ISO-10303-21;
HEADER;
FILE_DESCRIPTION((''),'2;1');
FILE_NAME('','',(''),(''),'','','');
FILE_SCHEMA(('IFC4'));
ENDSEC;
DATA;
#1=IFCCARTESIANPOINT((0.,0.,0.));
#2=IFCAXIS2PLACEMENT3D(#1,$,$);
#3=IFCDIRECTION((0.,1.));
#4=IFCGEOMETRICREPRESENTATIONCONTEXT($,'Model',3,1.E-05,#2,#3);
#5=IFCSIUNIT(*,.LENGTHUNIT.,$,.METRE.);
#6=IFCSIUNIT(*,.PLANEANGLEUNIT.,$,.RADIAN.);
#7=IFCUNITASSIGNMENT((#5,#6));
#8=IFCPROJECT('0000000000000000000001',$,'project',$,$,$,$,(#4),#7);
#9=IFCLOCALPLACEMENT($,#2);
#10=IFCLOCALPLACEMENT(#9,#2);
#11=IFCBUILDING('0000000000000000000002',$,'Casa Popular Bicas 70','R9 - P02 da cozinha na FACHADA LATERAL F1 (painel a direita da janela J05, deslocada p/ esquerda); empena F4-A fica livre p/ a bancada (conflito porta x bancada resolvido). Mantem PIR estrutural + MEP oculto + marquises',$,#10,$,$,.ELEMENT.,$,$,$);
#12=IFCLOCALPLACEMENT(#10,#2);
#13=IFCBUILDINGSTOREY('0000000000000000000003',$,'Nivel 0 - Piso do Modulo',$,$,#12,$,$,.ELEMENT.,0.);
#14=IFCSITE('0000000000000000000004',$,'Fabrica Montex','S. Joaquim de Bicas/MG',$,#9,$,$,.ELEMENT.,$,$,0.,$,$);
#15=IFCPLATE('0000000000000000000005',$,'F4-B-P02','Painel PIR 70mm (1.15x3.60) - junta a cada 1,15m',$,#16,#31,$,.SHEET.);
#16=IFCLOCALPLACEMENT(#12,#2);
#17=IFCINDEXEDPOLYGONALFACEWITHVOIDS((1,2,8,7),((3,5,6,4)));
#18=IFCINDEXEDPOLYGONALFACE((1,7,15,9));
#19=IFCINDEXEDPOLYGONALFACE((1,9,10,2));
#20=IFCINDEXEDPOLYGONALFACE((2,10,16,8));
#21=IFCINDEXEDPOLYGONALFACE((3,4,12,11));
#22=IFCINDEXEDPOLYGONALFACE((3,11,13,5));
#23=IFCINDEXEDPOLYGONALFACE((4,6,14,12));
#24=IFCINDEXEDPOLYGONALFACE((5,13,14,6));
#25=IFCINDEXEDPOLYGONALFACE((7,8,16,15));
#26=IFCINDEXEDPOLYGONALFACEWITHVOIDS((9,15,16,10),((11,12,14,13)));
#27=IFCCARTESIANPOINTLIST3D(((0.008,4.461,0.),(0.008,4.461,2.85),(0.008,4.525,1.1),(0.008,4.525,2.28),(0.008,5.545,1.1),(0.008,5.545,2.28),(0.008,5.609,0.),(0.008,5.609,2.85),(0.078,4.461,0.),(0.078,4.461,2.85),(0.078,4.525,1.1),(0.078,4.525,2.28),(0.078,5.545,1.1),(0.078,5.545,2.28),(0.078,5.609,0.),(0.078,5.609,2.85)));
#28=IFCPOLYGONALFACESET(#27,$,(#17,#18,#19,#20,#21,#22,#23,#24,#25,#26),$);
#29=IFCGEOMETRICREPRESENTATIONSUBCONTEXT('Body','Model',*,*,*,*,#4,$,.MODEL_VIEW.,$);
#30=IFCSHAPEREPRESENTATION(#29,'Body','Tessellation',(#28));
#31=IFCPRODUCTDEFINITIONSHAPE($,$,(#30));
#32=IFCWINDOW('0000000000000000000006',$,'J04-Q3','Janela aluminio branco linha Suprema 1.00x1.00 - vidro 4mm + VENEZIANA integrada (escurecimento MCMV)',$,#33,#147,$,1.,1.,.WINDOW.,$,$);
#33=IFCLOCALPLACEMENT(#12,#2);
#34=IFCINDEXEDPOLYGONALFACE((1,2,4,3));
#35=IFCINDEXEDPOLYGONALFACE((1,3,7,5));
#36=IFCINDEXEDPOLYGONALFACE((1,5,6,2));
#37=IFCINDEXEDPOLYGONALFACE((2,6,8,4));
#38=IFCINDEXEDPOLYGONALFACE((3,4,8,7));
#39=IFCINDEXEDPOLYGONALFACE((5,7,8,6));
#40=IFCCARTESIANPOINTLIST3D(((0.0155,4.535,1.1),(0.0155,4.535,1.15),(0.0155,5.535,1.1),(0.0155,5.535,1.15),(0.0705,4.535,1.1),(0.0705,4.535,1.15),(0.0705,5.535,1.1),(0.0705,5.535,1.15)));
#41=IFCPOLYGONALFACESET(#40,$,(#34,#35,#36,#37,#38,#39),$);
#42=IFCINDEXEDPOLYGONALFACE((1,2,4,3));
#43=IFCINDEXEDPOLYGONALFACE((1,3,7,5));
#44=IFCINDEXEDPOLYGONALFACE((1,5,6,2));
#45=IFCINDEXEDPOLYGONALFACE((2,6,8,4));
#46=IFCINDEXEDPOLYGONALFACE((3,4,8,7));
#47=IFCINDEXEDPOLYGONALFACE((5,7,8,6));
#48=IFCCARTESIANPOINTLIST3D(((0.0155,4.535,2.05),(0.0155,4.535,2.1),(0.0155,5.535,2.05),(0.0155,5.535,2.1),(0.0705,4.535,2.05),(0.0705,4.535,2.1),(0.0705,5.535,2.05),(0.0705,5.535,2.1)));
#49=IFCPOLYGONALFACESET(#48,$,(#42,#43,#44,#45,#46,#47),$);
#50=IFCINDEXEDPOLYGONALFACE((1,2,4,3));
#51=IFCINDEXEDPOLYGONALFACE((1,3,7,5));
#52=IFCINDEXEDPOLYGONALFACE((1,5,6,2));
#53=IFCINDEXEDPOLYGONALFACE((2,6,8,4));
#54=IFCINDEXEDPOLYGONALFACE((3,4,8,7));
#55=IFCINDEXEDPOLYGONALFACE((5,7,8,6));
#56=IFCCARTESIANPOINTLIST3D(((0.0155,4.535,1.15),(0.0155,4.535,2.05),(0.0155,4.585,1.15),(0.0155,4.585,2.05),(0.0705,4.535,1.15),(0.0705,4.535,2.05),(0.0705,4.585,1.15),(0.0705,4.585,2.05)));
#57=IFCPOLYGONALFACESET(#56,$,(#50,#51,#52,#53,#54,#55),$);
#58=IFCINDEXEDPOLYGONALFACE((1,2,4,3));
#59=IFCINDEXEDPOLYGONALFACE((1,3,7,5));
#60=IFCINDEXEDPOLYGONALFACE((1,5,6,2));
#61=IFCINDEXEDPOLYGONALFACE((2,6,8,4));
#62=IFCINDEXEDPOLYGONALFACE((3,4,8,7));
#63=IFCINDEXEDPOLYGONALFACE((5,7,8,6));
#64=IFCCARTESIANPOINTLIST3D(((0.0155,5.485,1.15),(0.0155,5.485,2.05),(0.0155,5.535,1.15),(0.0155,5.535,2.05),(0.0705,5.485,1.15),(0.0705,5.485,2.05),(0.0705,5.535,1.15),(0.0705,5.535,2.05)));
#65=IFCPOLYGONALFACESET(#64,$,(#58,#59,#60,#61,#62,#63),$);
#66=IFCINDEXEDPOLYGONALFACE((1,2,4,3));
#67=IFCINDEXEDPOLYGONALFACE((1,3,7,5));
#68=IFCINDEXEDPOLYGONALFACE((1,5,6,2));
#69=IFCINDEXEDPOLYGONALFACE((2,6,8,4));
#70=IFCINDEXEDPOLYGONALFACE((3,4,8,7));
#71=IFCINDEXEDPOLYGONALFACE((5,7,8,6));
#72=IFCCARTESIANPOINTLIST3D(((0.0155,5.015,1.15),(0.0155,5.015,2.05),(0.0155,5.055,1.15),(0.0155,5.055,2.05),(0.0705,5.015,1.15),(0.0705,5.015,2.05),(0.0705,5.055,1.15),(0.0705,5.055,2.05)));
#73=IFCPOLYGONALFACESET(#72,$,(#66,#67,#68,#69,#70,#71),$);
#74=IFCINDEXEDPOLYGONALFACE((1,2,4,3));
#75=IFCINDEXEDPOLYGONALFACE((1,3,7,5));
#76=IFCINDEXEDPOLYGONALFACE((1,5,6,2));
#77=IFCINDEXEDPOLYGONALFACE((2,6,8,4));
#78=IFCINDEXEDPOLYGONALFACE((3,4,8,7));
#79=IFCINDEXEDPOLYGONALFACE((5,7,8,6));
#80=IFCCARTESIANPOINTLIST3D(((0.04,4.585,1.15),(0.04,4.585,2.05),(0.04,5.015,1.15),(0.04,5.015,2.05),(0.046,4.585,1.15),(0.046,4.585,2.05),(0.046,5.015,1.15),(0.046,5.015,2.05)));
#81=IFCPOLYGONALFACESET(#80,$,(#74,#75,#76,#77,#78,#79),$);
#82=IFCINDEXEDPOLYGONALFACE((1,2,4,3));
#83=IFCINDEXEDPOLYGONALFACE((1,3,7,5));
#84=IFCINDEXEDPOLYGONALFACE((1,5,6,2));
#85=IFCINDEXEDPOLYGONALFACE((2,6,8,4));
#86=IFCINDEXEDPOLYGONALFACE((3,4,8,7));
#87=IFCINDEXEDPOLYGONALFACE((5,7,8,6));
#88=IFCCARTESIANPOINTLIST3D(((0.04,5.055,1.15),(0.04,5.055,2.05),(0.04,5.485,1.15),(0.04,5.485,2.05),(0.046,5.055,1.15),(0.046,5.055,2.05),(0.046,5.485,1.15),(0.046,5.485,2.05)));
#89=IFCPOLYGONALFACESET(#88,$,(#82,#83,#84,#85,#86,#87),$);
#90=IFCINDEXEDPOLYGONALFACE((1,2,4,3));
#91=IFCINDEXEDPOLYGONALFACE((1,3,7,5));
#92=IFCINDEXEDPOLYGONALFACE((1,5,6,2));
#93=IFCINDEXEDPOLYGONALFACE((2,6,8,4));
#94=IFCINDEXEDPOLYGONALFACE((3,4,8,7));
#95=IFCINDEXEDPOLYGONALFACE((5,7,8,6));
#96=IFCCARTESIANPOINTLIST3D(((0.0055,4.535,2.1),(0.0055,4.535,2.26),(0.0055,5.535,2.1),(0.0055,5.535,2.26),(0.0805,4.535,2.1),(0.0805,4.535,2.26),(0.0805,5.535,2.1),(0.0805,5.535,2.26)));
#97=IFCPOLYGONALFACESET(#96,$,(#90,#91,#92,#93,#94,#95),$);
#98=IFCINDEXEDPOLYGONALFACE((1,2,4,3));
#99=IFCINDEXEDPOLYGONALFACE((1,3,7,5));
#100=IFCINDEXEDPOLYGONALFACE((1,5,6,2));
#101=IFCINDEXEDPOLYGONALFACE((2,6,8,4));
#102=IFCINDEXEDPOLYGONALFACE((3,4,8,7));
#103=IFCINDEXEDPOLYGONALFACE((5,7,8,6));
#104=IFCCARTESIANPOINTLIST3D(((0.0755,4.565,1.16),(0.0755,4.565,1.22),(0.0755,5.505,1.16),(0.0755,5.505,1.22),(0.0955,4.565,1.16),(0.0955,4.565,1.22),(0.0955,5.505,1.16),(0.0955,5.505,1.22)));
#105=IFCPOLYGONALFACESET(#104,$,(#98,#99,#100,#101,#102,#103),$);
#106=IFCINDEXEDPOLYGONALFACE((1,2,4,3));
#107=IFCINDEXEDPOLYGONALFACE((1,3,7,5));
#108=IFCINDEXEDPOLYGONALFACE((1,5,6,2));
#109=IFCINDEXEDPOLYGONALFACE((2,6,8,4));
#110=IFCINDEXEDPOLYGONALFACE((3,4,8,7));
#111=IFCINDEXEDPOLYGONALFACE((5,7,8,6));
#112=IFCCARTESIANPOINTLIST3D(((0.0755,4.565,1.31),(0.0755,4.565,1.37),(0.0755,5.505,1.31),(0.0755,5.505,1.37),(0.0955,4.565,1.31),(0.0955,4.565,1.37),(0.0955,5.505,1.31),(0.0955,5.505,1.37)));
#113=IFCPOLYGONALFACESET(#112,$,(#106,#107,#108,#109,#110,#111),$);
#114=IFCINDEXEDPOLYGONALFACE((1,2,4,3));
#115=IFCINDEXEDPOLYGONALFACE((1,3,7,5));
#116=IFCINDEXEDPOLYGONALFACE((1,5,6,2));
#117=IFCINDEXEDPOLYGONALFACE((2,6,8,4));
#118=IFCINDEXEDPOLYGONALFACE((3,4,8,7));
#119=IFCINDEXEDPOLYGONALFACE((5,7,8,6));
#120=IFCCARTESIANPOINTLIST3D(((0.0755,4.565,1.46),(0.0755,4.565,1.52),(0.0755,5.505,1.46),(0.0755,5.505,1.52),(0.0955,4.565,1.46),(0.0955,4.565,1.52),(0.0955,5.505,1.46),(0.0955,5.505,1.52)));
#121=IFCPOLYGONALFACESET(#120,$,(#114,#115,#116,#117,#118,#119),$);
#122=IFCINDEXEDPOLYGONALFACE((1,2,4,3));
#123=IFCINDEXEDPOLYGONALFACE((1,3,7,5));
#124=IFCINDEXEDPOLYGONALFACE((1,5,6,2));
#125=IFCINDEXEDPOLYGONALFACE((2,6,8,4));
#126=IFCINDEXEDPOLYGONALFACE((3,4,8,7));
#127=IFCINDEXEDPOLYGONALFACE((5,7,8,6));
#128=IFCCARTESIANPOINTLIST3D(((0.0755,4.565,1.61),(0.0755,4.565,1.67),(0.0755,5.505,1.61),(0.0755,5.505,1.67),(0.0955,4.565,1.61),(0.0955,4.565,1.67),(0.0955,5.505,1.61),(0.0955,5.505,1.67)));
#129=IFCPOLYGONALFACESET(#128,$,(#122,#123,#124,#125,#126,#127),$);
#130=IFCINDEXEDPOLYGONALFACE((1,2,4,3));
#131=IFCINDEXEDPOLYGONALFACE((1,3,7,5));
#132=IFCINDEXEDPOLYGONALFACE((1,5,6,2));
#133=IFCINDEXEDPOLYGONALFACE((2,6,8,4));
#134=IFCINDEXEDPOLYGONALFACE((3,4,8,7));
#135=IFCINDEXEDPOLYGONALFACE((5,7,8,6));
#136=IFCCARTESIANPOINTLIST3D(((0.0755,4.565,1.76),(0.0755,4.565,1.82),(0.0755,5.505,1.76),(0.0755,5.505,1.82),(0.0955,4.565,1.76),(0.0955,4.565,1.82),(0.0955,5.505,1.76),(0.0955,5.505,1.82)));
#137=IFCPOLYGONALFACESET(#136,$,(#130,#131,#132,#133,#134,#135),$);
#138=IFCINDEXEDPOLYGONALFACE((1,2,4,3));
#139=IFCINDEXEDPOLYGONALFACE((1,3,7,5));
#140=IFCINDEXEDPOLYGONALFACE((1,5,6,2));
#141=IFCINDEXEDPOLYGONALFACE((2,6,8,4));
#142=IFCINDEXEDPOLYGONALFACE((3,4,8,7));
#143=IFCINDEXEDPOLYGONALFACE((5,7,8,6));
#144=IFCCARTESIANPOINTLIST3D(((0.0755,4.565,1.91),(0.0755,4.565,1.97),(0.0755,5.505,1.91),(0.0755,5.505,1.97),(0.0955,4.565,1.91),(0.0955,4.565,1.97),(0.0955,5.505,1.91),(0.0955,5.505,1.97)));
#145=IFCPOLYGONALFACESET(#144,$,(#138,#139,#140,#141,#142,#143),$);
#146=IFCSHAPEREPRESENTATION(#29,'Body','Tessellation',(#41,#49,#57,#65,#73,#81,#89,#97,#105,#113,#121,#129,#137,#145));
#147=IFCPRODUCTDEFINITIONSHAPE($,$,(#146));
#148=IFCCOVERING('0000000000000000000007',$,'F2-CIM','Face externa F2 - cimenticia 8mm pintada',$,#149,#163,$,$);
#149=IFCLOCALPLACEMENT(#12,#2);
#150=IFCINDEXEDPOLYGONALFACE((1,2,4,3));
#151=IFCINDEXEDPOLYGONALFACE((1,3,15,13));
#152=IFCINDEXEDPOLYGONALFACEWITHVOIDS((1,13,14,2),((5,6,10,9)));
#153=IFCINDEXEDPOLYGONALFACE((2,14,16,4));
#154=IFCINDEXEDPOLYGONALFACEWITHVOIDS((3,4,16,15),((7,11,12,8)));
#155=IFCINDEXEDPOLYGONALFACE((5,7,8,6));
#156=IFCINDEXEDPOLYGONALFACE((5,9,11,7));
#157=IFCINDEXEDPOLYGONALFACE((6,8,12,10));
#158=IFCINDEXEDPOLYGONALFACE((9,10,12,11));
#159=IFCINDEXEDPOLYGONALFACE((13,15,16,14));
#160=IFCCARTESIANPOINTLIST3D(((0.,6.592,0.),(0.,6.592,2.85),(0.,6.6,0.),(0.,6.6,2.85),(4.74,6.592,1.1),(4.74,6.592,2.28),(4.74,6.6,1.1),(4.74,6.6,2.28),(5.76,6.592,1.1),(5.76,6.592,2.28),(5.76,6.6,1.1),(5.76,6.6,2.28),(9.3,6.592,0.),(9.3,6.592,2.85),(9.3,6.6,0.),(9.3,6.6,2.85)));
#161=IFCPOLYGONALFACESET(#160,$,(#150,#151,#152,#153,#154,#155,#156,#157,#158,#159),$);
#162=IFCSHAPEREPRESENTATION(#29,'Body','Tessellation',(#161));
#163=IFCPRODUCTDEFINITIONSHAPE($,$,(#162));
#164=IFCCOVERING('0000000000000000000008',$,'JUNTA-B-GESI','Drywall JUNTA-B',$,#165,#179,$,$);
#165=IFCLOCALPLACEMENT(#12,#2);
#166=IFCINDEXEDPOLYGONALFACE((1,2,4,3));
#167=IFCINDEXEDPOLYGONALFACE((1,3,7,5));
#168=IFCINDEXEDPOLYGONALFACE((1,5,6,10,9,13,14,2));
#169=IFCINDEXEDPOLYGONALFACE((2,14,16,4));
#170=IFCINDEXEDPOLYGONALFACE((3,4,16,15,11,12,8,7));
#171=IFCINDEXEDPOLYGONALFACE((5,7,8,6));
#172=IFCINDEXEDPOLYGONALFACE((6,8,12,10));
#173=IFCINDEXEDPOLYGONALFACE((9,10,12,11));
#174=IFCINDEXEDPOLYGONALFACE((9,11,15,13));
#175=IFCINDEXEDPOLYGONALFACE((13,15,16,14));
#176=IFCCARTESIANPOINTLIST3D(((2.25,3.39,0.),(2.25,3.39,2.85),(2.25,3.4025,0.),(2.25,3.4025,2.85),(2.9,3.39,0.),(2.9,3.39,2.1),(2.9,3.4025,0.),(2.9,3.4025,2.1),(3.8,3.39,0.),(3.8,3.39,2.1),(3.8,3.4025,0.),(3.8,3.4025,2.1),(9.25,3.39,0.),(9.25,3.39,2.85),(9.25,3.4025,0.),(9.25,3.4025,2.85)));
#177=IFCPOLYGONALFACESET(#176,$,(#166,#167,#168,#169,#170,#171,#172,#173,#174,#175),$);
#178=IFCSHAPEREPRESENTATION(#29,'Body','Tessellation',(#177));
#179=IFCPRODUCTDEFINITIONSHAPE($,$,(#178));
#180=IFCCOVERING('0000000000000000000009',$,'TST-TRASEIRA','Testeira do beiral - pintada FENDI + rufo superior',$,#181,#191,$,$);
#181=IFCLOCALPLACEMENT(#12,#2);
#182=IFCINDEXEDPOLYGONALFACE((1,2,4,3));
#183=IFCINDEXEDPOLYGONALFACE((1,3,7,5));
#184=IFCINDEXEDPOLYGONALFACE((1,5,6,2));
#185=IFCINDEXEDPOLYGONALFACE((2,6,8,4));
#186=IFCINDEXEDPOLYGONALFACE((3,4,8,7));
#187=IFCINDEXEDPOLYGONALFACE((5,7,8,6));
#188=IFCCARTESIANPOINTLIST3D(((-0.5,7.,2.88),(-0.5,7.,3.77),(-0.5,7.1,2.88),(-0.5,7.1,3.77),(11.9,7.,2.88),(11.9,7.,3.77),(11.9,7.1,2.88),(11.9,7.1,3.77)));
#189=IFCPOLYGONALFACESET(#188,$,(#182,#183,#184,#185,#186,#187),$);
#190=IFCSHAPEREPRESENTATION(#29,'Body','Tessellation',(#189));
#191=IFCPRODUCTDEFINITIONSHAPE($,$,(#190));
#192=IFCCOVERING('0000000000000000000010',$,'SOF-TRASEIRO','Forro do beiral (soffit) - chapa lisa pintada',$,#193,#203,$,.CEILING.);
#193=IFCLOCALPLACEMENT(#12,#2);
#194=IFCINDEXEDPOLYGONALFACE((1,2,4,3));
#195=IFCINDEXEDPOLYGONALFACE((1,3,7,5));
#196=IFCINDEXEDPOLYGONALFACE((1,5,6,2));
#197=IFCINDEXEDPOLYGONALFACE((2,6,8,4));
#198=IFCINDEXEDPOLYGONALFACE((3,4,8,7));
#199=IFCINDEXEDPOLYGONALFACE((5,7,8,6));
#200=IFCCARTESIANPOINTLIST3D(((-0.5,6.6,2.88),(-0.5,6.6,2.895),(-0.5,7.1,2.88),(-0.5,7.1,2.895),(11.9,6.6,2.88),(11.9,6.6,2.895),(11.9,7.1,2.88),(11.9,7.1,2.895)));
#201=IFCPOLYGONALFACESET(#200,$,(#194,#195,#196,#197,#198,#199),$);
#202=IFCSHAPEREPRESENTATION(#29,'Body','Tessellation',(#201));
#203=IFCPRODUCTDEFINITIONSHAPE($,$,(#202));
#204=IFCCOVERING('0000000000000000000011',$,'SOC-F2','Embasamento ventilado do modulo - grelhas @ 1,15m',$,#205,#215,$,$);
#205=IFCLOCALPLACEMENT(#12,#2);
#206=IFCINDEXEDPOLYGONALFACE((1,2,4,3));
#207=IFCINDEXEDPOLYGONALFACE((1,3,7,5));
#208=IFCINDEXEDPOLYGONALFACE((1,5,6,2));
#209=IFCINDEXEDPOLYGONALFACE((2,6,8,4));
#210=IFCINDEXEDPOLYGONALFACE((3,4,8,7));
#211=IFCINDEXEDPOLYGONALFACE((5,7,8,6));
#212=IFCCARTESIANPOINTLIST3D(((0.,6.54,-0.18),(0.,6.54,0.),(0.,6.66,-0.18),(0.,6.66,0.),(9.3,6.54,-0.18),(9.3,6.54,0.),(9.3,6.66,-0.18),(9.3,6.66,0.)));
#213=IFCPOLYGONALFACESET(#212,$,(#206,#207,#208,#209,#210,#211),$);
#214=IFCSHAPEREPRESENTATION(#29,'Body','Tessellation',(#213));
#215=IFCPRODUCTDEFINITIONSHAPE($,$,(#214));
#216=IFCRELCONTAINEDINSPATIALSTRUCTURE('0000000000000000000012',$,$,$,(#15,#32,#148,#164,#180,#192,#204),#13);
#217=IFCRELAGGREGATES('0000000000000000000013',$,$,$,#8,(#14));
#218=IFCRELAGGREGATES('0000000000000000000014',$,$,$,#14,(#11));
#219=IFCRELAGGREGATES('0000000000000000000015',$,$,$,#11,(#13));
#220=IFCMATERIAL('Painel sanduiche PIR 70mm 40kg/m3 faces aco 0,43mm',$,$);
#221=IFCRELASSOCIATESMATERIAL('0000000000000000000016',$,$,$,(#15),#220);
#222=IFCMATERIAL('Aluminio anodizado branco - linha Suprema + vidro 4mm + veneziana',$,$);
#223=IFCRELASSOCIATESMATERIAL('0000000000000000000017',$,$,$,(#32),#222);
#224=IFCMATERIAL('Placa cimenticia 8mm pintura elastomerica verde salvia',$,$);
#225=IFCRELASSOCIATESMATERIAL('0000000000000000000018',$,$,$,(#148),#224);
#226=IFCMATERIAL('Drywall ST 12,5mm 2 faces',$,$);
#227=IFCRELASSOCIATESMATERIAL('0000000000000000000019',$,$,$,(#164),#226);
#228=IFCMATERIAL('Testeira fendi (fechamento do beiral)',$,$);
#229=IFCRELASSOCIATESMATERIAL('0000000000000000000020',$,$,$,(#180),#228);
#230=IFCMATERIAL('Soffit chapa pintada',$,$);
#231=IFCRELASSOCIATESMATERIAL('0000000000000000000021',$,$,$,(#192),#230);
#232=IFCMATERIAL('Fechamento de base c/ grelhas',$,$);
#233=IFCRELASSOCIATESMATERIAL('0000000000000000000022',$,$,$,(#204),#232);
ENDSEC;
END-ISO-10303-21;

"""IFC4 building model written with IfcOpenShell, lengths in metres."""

from ifc_helpers import new_model, si_unit, direction, frame, frame_2d, origin, origin_2d, place, context, subcontext, project, spatial, rectangle, extrude, material, element, fill, save


model = new_model("IFC4")

# Units and contexts
model_context = context("Model", 3, precision=1e-05, world=origin(), true_north=direction((0.0, 1.0)))
body_context = subcontext(model_context, "Body", "Model", "MODEL_VIEW")
ifc_project = project(units=[si_unit("LENGTHUNIT", "METRE"), si_unit("PLANEANGLEUNIT", "RADIAN")], contexts=[model_context])

# Site, building, storey
site_placement = place(None, origin())
site = spatial("IfcSite", under=ifc_project, at=site_placement, Name="Fabrica Montex", Description="S. Joaquim de Bicas/MG", CompositionType="ELEMENT", RefElevation=0.0)
building_placement = place(site_placement, origin())
building = spatial("IfcBuilding", under=site, at=building_placement, Name="Casa Popular Bicas 70", Description="R9 - P02 da cozinha na FACHADA LATERAL F1 (painel a direita da janela J05, deslocada p/ esquerda); empena F4-A fica livre p/ a bancada (conflito porta x bancada resolvido). Mantem PIR estrutural + MEP oculto + marquises", CompositionType="ELEMENT")
storey_placement = place(building_placement, origin())
storey = spatial("IfcBuildingStorey", under=building, at=storey_placement, Name="Nivel 0 - Piso do Modulo", CompositionType="ELEMENT", Elevation=0.0)

# Shared definitions
ifc_material_1 = material(Name="Painel sanduiche PIR 70mm 40kg/m3 faces aco 0,43mm")

# Plate, opening, window
plate_1_placement = place(storey_placement, frame((0.043, 4.461, 0.0), x_axis=(0.0, 1.0, 0.0)))
plate_1 = element("IfcPlate", 1, at=plate_1_placement, inside=storey, material=ifc_material_1, Name="F4-B-P02", Description="Painel PIR 70mm (1.15x3.60) - junta a cada 1,15m", PredefinedType="SHEET", context=body_context, shape_type="SweptSolid", body=[
    extrude(rectangle(XDim=1.148, YDim=0.07, at=frame_2d((0.574, 0.0))), origin(), (0.0, 0.0, 1.0), 2.85),
])
opening_1_placement = place(storey_placement, frame((0.043, 4.535, 1.1), x_axis=(0.0, 1.0, 0.0)))
opening_1 = element("IfcOpeningElement", 2, at=opening_1_placement, cuts=plate_1, PredefinedType="OPENING", context=body_context, shape_type="SweptSolid", body=[
    extrude(rectangle(XDim=1.02, YDim=0.3, at=frame_2d((0.5, 0.0))), origin(), (0.0, 0.0, 1.0), 1.18),
])
ifc_material_2 = material(Name="Aluminio anodizado branco - linha Suprema + vidro 4mm + veneziana")
window_placement = place(storey_placement, frame((0.043, 4.535, 1.1), x_axis=(0.0, 1.0, 0.0)))
window = element("IfcWindow", 3, at=window_placement, inside=storey, material=ifc_material_2, Name="J04-Q3", Description="Janela aluminio branco linha Suprema 1.00x1.00 - vidro 4mm + VENEZIANA integrada (escurecimento MCMV)", OverallHeight=1.0, OverallWidth=1.0, PredefinedType="WINDOW", context=body_context, shape_type="SweptSolid", body=[
    extrude(rectangle(XDim=1.0, YDim=0.055, at=frame_2d((0.5, 0.0))), origin(), (0.0, 0.0, 1.0), 0.05),
    extrude(rectangle(XDim=1.0, YDim=0.055, at=frame_2d((0.5, 0.0))), frame((0.0, 0.0, 0.95)), (0.0, 0.0, 1.0), 0.05),
    extrude(rectangle(XDim=0.05, YDim=0.055, at=frame_2d((0.025, 0.0))), frame((0.0, 0.0, 0.05)), (0.0, 0.0, 1.0), 0.9),
    extrude(rectangle(XDim=0.05, YDim=0.055, at=frame_2d((0.975, 0.0))), frame((0.0, 0.0, 0.05)), (0.0, 0.0, 1.0), 0.9),
    extrude(rectangle(XDim=0.04, YDim=0.055, at=frame_2d((0.5, 0.0))), frame((0.0, 0.0, 0.05)), (0.0, 0.0, 1.0), 0.9),
    extrude(rectangle(XDim=0.43, YDim=0.006, at=frame_2d((0.265, 0.0))), frame((0.0, 0.0, 0.05)), (0.0, 0.0, 1.0), 0.9),
    extrude(rectangle(XDim=0.43, YDim=0.006, at=frame_2d((0.735, 0.0))), frame((0.0, 0.0, 0.05)), (0.0, 0.0, 1.0), 0.9),
    extrude(rectangle(XDim=1.0, YDim=0.075, at=frame_2d((0.5, 0.0))), frame((0.0, 0.0, 1.0)), (0.0, 0.0, 1.0), 0.16),
    extrude(rectangle(XDim=0.94, YDim=0.02, at=frame_2d((0.5, -0.0425))), frame((0.0, 0.0, 0.06)), (0.0, 0.0, 1.0), 0.06),
    extrude(rectangle(XDim=0.94, YDim=0.02, at=frame_2d((0.5, -0.0425))), frame((0.0, 0.0, 0.21)), (0.0, 0.0, 1.0), 0.06),
    extrude(rectangle(XDim=0.94, YDim=0.02, at=frame_2d((0.5, -0.0425))), frame((0.0, 0.0, 0.36)), (0.0, 0.0, 1.0), 0.06),
    extrude(rectangle(XDim=0.94, YDim=0.02, at=frame_2d((0.5, -0.0425))), frame((0.0, 0.0, 0.51)), (0.0, 0.0, 1.0), 0.06),
    extrude(rectangle(XDim=0.94, YDim=0.02, at=frame_2d((0.5, -0.0425))), frame((0.0, 0.0, 0.66)), (0.0, 0.0, 1.0), 0.06),
    extrude(rectangle(XDim=0.94, YDim=0.02, at=frame_2d((0.5, -0.0425))), frame((0.0, 0.0, 0.81)), (0.0, 0.0, 1.0), 0.06),
])
fill(opening_1, window)

# Coverings, openings
ifc_material_3 = material(Name="Placa cimenticia 8mm pintura elastomerica verde salvia")
covering_1_placement = place(storey_placement, frame((0.0, 6.596, 0.0), x_axis=(1.0, 0.0, 0.0)))
covering_1 = element("IfcCovering", 4, at=covering_1_placement, inside=storey, material=ifc_material_3, Name="F2-CIM", Description="Face externa F2 - cimenticia 8mm pintada", context=body_context, shape_type="SweptSolid", body=[
    extrude(rectangle(XDim=9.3, YDim=0.008, at=frame_2d((4.65, 0.0))), origin(), (0.0, 0.0, 1.0), 2.85),
])
opening_2_placement = place(storey_placement, frame((4.75, 6.596, 1.1)))
element("IfcOpeningElement", 5, at=opening_2_placement, cuts=covering_1, PredefinedType="OPENING", context=body_context, shape_type="SweptSolid", body=[
    extrude(rectangle(XDim=1.02, YDim=0.03, at=frame_2d((0.5, 0.0))), origin(), (0.0, 0.0, 1.0), 1.18),
])
ifc_material_4 = material(Name="Drywall ST 12,5mm 2 faces")
covering_2_placement = place(storey_placement, frame((2.25, 3.3962, 0.0), x_axis=(1.0, 0.0, 0.0)))
covering_2 = element("IfcCovering", 6, at=covering_2_placement, inside=storey, material=ifc_material_4, Name="JUNTA-B-GESI", Description="Drywall JUNTA-B", context=body_context, shape_type="SweptSolid", body=[
    extrude(rectangle(XDim=7.0, YDim=0.0125, at=frame_2d((3.5, 0.0))), origin(), (0.0, 0.0, 1.0), 2.85),
])
opening_3_placement = place(storey_placement, frame((3.35, 3.3962, 0.0)))
element("IfcOpeningElement", 7, at=opening_3_placement, cuts=covering_2, PredefinedType="OPENING", context=body_context, shape_type="SweptSolid", body=[
    extrude(rectangle(XDim=0.9, YDim=0.0425, at=origin_2d()), origin(), (0.0, 0.0, 1.0), 2.1),
])

# Coverings
ifc_material_5 = material(Name="Testeira fendi (fechamento do beiral)")
covering_3_placement = place(storey_placement, frame((-0.5, 7.05, 2.88), x_axis=(1.0, 0.0, 0.0)))
element("IfcCovering", 8, at=covering_3_placement, inside=storey, material=ifc_material_5, Name="TST-TRASEIRA", Description="Testeira do beiral - pintada FENDI + rufo superior", context=body_context, shape_type="SweptSolid", body=[
    extrude(rectangle(XDim=12.4, YDim=0.1, at=frame_2d((6.2, 0.0))), origin(), (0.0, 0.0, 1.0), 0.89),
])
ifc_material_6 = material(Name="Soffit chapa pintada")
covering_4_placement = place(storey_placement, frame((-0.5, 6.6, 2.88)))
element("IfcCovering", 9, at=covering_4_placement, inside=storey, material=ifc_material_6, Name="SOF-TRASEIRO", Description="Forro do beiral (soffit) - chapa lisa pintada", PredefinedType="CEILING", context=body_context, shape_type="SweptSolid", body=[
    extrude(rectangle(XDim=12.4, YDim=0.5, at=frame_2d((6.2, 0.25))), origin(), (0.0, 0.0, 1.0), 0.015),
])
ifc_material_7 = material(Name="Fechamento de base c/ grelhas")
covering_5_placement = place(storey_placement, frame((0.0, 6.6, -0.18), x_axis=(1.0, 0.0, 0.0)))
element("IfcCovering", 10, at=covering_5_placement, inside=storey, material=ifc_material_7, Name="SOC-F2", Description="Embasamento ventilado do modulo - grelhas @ 1,15m", context=body_context, shape_type="SweptSolid", body=[
    extrude(rectangle(XDim=9.3, YDim=0.12, at=frame_2d((4.65, 0.0))), origin(), (0.0, 0.0, 1.0), 0.18),
])

save(model, "model.ifc")
